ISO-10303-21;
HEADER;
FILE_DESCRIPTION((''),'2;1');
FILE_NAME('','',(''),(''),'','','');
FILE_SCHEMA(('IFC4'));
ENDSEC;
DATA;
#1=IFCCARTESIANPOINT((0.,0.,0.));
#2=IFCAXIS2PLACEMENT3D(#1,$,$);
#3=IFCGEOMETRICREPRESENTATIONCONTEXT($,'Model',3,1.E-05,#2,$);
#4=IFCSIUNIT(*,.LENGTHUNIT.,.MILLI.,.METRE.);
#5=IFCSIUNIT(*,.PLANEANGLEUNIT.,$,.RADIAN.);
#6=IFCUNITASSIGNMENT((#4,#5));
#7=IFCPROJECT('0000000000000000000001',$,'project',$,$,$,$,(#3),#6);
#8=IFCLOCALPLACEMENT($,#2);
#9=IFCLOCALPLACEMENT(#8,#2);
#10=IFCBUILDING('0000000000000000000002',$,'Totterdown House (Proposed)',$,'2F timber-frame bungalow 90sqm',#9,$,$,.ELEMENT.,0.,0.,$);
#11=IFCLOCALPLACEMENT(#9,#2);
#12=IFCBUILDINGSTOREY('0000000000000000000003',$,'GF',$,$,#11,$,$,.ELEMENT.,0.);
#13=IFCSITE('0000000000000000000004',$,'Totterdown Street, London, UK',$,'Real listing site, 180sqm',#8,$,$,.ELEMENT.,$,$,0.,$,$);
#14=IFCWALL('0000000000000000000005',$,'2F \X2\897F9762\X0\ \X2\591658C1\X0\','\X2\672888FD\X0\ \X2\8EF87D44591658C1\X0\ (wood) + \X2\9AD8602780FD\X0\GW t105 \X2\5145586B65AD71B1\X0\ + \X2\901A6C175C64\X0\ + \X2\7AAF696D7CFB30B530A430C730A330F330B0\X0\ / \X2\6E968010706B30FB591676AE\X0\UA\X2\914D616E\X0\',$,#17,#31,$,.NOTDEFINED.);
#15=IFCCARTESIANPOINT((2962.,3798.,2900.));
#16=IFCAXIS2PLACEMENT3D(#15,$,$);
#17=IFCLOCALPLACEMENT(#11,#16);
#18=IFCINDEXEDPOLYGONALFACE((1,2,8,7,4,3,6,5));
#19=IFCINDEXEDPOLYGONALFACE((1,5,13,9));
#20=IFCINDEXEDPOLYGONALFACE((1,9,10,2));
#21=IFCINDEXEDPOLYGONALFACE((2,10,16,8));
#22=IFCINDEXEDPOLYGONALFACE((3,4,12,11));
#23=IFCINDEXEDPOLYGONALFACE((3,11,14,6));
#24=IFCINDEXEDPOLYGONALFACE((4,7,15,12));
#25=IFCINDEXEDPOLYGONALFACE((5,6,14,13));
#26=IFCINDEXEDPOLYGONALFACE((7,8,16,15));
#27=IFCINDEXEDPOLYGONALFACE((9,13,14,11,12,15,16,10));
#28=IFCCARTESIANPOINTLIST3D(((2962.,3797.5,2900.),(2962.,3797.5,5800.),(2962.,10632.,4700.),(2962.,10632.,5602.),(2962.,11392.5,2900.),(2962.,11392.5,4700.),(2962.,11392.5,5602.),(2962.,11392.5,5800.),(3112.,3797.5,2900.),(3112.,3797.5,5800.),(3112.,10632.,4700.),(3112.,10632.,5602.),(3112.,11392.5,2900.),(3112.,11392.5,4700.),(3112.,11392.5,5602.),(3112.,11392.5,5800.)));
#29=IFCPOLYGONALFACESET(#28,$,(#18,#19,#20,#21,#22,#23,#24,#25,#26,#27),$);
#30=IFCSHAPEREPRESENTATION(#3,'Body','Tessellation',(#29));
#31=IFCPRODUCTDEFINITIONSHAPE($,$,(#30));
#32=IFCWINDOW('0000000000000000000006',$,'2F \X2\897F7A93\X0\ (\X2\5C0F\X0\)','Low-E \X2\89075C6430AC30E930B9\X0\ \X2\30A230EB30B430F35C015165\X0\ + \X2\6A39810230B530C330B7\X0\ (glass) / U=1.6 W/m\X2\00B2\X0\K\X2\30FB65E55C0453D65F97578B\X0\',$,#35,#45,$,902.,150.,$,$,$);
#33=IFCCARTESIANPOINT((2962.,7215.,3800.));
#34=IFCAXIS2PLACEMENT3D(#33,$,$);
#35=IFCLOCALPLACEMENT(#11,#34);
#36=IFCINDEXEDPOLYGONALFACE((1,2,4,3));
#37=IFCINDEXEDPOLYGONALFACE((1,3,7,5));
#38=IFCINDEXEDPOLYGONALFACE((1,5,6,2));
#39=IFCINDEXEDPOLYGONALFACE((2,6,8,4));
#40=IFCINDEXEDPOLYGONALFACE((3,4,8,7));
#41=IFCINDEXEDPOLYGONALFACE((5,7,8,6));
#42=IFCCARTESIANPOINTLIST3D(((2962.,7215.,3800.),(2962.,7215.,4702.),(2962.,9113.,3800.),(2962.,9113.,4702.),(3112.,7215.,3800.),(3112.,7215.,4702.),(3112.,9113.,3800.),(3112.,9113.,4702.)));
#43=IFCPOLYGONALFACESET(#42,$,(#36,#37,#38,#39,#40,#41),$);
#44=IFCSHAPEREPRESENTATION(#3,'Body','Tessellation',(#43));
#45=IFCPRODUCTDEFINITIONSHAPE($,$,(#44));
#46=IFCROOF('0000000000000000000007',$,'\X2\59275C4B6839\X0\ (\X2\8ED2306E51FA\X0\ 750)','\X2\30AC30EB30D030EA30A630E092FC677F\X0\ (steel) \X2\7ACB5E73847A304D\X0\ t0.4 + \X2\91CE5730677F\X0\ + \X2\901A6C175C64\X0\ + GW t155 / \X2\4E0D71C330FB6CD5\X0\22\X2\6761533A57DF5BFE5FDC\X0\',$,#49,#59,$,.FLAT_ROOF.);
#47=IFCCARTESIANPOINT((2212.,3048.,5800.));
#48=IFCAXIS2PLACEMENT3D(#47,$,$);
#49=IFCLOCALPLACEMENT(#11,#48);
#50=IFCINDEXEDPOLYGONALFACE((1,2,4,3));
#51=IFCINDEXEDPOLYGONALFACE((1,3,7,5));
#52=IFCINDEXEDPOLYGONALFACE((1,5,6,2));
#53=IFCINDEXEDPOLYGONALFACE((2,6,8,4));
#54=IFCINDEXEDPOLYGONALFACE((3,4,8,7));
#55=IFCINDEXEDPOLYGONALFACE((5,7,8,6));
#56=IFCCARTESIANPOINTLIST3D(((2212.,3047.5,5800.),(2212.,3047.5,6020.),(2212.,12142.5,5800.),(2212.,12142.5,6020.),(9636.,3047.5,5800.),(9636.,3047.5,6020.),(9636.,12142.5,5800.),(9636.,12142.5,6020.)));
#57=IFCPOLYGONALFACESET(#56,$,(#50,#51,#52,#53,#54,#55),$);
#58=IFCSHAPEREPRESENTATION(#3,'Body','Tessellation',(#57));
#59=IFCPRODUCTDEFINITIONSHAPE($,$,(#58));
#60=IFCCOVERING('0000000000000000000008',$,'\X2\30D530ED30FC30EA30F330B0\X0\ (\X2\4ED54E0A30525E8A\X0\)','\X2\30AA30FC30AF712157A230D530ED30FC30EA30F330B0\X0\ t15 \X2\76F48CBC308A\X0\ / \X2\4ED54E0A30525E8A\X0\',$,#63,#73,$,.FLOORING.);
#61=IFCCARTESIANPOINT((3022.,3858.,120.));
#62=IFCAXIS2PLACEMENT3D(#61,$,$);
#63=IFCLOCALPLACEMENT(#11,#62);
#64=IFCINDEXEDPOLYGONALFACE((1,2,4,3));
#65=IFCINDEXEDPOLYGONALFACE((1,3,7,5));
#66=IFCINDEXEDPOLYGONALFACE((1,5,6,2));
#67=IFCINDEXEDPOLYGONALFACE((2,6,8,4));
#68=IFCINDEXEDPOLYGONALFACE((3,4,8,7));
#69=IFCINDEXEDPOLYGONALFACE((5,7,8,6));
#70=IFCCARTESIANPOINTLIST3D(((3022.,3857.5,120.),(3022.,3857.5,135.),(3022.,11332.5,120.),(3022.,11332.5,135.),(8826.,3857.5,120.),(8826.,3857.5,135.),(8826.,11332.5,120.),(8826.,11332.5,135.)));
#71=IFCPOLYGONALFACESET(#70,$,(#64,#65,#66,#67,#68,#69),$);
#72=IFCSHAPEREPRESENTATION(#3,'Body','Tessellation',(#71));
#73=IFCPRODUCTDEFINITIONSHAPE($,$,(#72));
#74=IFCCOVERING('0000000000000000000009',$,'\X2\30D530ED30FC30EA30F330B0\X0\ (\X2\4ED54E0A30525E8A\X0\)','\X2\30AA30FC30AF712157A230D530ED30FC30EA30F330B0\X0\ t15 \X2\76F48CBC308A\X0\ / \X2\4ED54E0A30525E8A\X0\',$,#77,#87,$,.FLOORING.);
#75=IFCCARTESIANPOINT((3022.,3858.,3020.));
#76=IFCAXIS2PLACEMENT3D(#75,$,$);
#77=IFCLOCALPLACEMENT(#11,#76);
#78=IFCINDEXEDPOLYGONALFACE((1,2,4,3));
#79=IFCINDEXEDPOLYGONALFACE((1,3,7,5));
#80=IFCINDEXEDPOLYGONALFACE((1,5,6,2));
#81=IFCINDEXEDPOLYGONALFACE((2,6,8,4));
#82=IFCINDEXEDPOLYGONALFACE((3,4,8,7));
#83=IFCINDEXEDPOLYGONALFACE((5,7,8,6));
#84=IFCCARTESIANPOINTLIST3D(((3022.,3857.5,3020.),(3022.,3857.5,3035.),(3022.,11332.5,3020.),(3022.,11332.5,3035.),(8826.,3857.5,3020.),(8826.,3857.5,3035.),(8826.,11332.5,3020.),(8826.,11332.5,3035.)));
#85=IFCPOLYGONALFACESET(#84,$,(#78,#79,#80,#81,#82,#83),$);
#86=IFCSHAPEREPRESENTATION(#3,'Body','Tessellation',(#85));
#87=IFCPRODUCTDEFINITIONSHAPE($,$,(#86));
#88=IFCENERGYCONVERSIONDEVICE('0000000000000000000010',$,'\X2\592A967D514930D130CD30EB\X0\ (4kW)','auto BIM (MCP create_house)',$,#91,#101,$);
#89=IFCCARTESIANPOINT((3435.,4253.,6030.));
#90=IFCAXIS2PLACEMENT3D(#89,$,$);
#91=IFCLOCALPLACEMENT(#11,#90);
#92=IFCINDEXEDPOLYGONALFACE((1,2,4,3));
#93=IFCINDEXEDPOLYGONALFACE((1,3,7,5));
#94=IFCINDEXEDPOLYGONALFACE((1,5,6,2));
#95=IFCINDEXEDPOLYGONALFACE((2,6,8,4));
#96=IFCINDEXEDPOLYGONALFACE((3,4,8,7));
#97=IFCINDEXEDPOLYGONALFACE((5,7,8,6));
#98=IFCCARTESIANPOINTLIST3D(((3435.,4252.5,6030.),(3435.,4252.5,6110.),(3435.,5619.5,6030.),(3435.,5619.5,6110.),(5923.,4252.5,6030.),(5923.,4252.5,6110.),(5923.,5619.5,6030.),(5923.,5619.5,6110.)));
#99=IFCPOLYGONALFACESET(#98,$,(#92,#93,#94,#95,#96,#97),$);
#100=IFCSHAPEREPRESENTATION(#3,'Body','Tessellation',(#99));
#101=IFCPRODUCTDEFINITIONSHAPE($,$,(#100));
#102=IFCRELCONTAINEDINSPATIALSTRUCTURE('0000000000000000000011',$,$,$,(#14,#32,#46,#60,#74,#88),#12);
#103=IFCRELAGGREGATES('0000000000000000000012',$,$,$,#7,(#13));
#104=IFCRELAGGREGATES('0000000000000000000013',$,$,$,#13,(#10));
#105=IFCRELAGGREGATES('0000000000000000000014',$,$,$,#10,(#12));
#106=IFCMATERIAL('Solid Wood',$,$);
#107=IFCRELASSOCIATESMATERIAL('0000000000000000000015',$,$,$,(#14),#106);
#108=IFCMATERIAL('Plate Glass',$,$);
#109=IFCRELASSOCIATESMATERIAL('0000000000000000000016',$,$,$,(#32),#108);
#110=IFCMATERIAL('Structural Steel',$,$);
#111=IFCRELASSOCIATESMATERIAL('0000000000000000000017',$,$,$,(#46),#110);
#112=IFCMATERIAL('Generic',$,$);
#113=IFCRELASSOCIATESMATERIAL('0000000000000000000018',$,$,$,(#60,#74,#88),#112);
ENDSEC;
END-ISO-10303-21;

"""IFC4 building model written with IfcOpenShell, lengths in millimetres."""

from ifc_helpers import new_model, si_unit, frame, frame_2d, origin, place, context, project, spatial, rectangle, extrude, material, element, fill, save


model = new_model("IFC4")

# Units and contexts
model_context = context("Model", 3, precision=1e-05, world=origin())
ifc_project = project(units=[si_unit("LENGTHUNIT", "METRE", prefix="MILLI"), si_unit("PLANEANGLEUNIT", "RADIAN")], contexts=[model_context])

# Site, building, storey
site_placement = place(None, origin())
site = spatial("IfcSite", under=ifc_project, at=site_placement, Name="Totterdown Street, London, UK", ObjectType="Real listing site, 180sqm", CompositionType="ELEMENT", RefElevation=0.0)
building_placement = place(site_placement, origin())
building = spatial("IfcBuilding", under=site, at=building_placement, Name="Totterdown House (Proposed)", ObjectType="2F timber-frame bungalow 90sqm", CompositionType="ELEMENT", ElevationOfRefHeight=0.0, ElevationOfTerrain=0.0)
storey_placement = place(building_placement, origin())
storey = spatial("IfcBuildingStorey", under=building, at=storey_placement, Name="GF", CompositionType="ELEMENT", Elevation=0.0)

# Shared definitions
ifc_material_1 = material(Name="Solid Wood")

# Shared definitions
ifc_material_2 = material(Name="Plate Glass")

# Wall, opening, window
wall_1_placement = place(storey_placement, frame((2962.0, 3798.0, 2900.0)))
wall_1 = element("IfcWall", 1, at=wall_1_placement, inside=storey, material=ifc_material_1, Name="2F 西面 外壁", Description="木製 軸組外壁 (wood) + 高性能GW t105 充填断熱 + 通気層 + 窯業系サイディング / 準耐火・外皮UA配慮", PredefinedType="NOTDEFINED", context=model_context, shape_type="SweptSolid", body=[
    extrude(rectangle(XDim=150.0, YDim=7595.0, at=frame_2d((75.0, 3797.0))), frame((2962.0, 3798.0, 2900.0)), (0.0, 0.0, 1.0), 2900.0),
])
opening_1_placement = place(storey_placement, frame((2962.0, 7215.0, 3800.0)))
opening_1 = element("IfcOpeningElement", 2, at=opening_1_placement, cuts=wall_1, PredefinedType="NOTDEFINED", context=model_context, shape_type="SweptSolid", body=[
    extrude(rectangle(XDim=150.0, YDim=1898.0, at=frame_2d((75.0, 949.0))), frame((2962.0, 7215.0, 3800.0)), (0.0, 0.0, 1.0), 902.0),
])
window_1_placement = place(storey_placement, frame((2962.0, 7215.0, 3800.0)))
window_1 = element("IfcWindow", 3, at=window_1_placement, inside=storey, material=ifc_material_2, Name="2F 西窓 (小)", Description="Low-E 複層ガラス アルゴン封入 + 樹脂サッシ (glass) / U=1.6 W/m²K・日射取得型", OverallHeight=902.0, OverallWidth=150.0, context=model_context, shape_type="SweptSolid", body=[
    extrude(rectangle(XDim=150.0, YDim=1898.0, at=frame_2d((75.0, 949.0))), frame((2962.0, 7215.0, 3800.0)), (0.0, 0.0, 1.0), 902.0),
])
fill(opening_1, window_1)

# Roof
ifc_material_3 = material(Name="Structural Steel")
roof_placement = place(storey_placement, frame((2212.0, 3048.0, 5800.0)))
element("IfcRoof", 4, at=roof_placement, inside=storey, material=ifc_material_3, Name="大屋根 (軒の出 750)", Description="ガルバリウム鋼板 (steel) 立平葺き t0.4 + 野地板 + 通気層 + GW t155 / 不燃・法22条区域対応", PredefinedType="FLAT_ROOF", context=model_context, shape_type="SweptSolid", body=[
    extrude(rectangle(XDim=7424.0, YDim=9095.0, at=frame_2d((3712.0, 4547.0))), frame((2212.0, 3048.0, 5800.0)), (0.0, 0.0, 1.0), 220.0),
])

# Coverings
ifc_material_4 = material(Name="Generic")
covering_1_placement = place(storey_placement, frame((3022.0, 3858.0, 120.0)))
element("IfcCovering", 5, at=covering_1_placement, inside=storey, material=ifc_material_4, Name="フローリング (仕上げ床)", Description="オーク無垢フローリング t15 直貼り / 仕上げ床", PredefinedType="FLOORING", context=model_context, shape_type="SweptSolid", body=[
    extrude(rectangle(XDim=5804.0, YDim=7475.0, at=frame_2d((2902.0, 3737.0))), frame((3022.0, 3858.0, 120.0)), (0.0, 0.0, 1.0), 15.0),
])
covering_2_placement = place(storey_placement, frame((3022.0, 3858.0, 3020.0)))
element("IfcCovering", 6, at=covering_2_placement, inside=storey, material=ifc_material_4, Name="フローリング (仕上げ床)", Description="オーク無垢フローリング t15 直貼り / 仕上げ床", PredefinedType="FLOORING", context=model_context, shape_type="SweptSolid", body=[
    extrude(rectangle(XDim=5804.0, YDim=7475.0, at=frame_2d((2902.0, 3737.0))), frame((3022.0, 3858.0, 3020.0)), (0.0, 0.0, 1.0), 15.0),
])

# Energy conversion device
energy_conversion_device_placement = place(storey_placement, frame((3435.0, 4253.0, 6030.0)))
element("IfcEnergyConversionDevice", 7, at=energy_conversion_device_placement, inside=storey, material=ifc_material_4, Name="太陽光パネル (4kW)", Description="auto BIM (MCP create_house)", context=model_context, shape_type="SweptSolid", body=[
    extrude(rectangle(XDim=2488.0, YDim=1367.0, at=frame_2d((1244.0, 683.0))), frame((3435.0, 4253.0, 6030.0)), (0.0, 0.0, 1.0), 80.0),
])

save(model, "model.ifc")
